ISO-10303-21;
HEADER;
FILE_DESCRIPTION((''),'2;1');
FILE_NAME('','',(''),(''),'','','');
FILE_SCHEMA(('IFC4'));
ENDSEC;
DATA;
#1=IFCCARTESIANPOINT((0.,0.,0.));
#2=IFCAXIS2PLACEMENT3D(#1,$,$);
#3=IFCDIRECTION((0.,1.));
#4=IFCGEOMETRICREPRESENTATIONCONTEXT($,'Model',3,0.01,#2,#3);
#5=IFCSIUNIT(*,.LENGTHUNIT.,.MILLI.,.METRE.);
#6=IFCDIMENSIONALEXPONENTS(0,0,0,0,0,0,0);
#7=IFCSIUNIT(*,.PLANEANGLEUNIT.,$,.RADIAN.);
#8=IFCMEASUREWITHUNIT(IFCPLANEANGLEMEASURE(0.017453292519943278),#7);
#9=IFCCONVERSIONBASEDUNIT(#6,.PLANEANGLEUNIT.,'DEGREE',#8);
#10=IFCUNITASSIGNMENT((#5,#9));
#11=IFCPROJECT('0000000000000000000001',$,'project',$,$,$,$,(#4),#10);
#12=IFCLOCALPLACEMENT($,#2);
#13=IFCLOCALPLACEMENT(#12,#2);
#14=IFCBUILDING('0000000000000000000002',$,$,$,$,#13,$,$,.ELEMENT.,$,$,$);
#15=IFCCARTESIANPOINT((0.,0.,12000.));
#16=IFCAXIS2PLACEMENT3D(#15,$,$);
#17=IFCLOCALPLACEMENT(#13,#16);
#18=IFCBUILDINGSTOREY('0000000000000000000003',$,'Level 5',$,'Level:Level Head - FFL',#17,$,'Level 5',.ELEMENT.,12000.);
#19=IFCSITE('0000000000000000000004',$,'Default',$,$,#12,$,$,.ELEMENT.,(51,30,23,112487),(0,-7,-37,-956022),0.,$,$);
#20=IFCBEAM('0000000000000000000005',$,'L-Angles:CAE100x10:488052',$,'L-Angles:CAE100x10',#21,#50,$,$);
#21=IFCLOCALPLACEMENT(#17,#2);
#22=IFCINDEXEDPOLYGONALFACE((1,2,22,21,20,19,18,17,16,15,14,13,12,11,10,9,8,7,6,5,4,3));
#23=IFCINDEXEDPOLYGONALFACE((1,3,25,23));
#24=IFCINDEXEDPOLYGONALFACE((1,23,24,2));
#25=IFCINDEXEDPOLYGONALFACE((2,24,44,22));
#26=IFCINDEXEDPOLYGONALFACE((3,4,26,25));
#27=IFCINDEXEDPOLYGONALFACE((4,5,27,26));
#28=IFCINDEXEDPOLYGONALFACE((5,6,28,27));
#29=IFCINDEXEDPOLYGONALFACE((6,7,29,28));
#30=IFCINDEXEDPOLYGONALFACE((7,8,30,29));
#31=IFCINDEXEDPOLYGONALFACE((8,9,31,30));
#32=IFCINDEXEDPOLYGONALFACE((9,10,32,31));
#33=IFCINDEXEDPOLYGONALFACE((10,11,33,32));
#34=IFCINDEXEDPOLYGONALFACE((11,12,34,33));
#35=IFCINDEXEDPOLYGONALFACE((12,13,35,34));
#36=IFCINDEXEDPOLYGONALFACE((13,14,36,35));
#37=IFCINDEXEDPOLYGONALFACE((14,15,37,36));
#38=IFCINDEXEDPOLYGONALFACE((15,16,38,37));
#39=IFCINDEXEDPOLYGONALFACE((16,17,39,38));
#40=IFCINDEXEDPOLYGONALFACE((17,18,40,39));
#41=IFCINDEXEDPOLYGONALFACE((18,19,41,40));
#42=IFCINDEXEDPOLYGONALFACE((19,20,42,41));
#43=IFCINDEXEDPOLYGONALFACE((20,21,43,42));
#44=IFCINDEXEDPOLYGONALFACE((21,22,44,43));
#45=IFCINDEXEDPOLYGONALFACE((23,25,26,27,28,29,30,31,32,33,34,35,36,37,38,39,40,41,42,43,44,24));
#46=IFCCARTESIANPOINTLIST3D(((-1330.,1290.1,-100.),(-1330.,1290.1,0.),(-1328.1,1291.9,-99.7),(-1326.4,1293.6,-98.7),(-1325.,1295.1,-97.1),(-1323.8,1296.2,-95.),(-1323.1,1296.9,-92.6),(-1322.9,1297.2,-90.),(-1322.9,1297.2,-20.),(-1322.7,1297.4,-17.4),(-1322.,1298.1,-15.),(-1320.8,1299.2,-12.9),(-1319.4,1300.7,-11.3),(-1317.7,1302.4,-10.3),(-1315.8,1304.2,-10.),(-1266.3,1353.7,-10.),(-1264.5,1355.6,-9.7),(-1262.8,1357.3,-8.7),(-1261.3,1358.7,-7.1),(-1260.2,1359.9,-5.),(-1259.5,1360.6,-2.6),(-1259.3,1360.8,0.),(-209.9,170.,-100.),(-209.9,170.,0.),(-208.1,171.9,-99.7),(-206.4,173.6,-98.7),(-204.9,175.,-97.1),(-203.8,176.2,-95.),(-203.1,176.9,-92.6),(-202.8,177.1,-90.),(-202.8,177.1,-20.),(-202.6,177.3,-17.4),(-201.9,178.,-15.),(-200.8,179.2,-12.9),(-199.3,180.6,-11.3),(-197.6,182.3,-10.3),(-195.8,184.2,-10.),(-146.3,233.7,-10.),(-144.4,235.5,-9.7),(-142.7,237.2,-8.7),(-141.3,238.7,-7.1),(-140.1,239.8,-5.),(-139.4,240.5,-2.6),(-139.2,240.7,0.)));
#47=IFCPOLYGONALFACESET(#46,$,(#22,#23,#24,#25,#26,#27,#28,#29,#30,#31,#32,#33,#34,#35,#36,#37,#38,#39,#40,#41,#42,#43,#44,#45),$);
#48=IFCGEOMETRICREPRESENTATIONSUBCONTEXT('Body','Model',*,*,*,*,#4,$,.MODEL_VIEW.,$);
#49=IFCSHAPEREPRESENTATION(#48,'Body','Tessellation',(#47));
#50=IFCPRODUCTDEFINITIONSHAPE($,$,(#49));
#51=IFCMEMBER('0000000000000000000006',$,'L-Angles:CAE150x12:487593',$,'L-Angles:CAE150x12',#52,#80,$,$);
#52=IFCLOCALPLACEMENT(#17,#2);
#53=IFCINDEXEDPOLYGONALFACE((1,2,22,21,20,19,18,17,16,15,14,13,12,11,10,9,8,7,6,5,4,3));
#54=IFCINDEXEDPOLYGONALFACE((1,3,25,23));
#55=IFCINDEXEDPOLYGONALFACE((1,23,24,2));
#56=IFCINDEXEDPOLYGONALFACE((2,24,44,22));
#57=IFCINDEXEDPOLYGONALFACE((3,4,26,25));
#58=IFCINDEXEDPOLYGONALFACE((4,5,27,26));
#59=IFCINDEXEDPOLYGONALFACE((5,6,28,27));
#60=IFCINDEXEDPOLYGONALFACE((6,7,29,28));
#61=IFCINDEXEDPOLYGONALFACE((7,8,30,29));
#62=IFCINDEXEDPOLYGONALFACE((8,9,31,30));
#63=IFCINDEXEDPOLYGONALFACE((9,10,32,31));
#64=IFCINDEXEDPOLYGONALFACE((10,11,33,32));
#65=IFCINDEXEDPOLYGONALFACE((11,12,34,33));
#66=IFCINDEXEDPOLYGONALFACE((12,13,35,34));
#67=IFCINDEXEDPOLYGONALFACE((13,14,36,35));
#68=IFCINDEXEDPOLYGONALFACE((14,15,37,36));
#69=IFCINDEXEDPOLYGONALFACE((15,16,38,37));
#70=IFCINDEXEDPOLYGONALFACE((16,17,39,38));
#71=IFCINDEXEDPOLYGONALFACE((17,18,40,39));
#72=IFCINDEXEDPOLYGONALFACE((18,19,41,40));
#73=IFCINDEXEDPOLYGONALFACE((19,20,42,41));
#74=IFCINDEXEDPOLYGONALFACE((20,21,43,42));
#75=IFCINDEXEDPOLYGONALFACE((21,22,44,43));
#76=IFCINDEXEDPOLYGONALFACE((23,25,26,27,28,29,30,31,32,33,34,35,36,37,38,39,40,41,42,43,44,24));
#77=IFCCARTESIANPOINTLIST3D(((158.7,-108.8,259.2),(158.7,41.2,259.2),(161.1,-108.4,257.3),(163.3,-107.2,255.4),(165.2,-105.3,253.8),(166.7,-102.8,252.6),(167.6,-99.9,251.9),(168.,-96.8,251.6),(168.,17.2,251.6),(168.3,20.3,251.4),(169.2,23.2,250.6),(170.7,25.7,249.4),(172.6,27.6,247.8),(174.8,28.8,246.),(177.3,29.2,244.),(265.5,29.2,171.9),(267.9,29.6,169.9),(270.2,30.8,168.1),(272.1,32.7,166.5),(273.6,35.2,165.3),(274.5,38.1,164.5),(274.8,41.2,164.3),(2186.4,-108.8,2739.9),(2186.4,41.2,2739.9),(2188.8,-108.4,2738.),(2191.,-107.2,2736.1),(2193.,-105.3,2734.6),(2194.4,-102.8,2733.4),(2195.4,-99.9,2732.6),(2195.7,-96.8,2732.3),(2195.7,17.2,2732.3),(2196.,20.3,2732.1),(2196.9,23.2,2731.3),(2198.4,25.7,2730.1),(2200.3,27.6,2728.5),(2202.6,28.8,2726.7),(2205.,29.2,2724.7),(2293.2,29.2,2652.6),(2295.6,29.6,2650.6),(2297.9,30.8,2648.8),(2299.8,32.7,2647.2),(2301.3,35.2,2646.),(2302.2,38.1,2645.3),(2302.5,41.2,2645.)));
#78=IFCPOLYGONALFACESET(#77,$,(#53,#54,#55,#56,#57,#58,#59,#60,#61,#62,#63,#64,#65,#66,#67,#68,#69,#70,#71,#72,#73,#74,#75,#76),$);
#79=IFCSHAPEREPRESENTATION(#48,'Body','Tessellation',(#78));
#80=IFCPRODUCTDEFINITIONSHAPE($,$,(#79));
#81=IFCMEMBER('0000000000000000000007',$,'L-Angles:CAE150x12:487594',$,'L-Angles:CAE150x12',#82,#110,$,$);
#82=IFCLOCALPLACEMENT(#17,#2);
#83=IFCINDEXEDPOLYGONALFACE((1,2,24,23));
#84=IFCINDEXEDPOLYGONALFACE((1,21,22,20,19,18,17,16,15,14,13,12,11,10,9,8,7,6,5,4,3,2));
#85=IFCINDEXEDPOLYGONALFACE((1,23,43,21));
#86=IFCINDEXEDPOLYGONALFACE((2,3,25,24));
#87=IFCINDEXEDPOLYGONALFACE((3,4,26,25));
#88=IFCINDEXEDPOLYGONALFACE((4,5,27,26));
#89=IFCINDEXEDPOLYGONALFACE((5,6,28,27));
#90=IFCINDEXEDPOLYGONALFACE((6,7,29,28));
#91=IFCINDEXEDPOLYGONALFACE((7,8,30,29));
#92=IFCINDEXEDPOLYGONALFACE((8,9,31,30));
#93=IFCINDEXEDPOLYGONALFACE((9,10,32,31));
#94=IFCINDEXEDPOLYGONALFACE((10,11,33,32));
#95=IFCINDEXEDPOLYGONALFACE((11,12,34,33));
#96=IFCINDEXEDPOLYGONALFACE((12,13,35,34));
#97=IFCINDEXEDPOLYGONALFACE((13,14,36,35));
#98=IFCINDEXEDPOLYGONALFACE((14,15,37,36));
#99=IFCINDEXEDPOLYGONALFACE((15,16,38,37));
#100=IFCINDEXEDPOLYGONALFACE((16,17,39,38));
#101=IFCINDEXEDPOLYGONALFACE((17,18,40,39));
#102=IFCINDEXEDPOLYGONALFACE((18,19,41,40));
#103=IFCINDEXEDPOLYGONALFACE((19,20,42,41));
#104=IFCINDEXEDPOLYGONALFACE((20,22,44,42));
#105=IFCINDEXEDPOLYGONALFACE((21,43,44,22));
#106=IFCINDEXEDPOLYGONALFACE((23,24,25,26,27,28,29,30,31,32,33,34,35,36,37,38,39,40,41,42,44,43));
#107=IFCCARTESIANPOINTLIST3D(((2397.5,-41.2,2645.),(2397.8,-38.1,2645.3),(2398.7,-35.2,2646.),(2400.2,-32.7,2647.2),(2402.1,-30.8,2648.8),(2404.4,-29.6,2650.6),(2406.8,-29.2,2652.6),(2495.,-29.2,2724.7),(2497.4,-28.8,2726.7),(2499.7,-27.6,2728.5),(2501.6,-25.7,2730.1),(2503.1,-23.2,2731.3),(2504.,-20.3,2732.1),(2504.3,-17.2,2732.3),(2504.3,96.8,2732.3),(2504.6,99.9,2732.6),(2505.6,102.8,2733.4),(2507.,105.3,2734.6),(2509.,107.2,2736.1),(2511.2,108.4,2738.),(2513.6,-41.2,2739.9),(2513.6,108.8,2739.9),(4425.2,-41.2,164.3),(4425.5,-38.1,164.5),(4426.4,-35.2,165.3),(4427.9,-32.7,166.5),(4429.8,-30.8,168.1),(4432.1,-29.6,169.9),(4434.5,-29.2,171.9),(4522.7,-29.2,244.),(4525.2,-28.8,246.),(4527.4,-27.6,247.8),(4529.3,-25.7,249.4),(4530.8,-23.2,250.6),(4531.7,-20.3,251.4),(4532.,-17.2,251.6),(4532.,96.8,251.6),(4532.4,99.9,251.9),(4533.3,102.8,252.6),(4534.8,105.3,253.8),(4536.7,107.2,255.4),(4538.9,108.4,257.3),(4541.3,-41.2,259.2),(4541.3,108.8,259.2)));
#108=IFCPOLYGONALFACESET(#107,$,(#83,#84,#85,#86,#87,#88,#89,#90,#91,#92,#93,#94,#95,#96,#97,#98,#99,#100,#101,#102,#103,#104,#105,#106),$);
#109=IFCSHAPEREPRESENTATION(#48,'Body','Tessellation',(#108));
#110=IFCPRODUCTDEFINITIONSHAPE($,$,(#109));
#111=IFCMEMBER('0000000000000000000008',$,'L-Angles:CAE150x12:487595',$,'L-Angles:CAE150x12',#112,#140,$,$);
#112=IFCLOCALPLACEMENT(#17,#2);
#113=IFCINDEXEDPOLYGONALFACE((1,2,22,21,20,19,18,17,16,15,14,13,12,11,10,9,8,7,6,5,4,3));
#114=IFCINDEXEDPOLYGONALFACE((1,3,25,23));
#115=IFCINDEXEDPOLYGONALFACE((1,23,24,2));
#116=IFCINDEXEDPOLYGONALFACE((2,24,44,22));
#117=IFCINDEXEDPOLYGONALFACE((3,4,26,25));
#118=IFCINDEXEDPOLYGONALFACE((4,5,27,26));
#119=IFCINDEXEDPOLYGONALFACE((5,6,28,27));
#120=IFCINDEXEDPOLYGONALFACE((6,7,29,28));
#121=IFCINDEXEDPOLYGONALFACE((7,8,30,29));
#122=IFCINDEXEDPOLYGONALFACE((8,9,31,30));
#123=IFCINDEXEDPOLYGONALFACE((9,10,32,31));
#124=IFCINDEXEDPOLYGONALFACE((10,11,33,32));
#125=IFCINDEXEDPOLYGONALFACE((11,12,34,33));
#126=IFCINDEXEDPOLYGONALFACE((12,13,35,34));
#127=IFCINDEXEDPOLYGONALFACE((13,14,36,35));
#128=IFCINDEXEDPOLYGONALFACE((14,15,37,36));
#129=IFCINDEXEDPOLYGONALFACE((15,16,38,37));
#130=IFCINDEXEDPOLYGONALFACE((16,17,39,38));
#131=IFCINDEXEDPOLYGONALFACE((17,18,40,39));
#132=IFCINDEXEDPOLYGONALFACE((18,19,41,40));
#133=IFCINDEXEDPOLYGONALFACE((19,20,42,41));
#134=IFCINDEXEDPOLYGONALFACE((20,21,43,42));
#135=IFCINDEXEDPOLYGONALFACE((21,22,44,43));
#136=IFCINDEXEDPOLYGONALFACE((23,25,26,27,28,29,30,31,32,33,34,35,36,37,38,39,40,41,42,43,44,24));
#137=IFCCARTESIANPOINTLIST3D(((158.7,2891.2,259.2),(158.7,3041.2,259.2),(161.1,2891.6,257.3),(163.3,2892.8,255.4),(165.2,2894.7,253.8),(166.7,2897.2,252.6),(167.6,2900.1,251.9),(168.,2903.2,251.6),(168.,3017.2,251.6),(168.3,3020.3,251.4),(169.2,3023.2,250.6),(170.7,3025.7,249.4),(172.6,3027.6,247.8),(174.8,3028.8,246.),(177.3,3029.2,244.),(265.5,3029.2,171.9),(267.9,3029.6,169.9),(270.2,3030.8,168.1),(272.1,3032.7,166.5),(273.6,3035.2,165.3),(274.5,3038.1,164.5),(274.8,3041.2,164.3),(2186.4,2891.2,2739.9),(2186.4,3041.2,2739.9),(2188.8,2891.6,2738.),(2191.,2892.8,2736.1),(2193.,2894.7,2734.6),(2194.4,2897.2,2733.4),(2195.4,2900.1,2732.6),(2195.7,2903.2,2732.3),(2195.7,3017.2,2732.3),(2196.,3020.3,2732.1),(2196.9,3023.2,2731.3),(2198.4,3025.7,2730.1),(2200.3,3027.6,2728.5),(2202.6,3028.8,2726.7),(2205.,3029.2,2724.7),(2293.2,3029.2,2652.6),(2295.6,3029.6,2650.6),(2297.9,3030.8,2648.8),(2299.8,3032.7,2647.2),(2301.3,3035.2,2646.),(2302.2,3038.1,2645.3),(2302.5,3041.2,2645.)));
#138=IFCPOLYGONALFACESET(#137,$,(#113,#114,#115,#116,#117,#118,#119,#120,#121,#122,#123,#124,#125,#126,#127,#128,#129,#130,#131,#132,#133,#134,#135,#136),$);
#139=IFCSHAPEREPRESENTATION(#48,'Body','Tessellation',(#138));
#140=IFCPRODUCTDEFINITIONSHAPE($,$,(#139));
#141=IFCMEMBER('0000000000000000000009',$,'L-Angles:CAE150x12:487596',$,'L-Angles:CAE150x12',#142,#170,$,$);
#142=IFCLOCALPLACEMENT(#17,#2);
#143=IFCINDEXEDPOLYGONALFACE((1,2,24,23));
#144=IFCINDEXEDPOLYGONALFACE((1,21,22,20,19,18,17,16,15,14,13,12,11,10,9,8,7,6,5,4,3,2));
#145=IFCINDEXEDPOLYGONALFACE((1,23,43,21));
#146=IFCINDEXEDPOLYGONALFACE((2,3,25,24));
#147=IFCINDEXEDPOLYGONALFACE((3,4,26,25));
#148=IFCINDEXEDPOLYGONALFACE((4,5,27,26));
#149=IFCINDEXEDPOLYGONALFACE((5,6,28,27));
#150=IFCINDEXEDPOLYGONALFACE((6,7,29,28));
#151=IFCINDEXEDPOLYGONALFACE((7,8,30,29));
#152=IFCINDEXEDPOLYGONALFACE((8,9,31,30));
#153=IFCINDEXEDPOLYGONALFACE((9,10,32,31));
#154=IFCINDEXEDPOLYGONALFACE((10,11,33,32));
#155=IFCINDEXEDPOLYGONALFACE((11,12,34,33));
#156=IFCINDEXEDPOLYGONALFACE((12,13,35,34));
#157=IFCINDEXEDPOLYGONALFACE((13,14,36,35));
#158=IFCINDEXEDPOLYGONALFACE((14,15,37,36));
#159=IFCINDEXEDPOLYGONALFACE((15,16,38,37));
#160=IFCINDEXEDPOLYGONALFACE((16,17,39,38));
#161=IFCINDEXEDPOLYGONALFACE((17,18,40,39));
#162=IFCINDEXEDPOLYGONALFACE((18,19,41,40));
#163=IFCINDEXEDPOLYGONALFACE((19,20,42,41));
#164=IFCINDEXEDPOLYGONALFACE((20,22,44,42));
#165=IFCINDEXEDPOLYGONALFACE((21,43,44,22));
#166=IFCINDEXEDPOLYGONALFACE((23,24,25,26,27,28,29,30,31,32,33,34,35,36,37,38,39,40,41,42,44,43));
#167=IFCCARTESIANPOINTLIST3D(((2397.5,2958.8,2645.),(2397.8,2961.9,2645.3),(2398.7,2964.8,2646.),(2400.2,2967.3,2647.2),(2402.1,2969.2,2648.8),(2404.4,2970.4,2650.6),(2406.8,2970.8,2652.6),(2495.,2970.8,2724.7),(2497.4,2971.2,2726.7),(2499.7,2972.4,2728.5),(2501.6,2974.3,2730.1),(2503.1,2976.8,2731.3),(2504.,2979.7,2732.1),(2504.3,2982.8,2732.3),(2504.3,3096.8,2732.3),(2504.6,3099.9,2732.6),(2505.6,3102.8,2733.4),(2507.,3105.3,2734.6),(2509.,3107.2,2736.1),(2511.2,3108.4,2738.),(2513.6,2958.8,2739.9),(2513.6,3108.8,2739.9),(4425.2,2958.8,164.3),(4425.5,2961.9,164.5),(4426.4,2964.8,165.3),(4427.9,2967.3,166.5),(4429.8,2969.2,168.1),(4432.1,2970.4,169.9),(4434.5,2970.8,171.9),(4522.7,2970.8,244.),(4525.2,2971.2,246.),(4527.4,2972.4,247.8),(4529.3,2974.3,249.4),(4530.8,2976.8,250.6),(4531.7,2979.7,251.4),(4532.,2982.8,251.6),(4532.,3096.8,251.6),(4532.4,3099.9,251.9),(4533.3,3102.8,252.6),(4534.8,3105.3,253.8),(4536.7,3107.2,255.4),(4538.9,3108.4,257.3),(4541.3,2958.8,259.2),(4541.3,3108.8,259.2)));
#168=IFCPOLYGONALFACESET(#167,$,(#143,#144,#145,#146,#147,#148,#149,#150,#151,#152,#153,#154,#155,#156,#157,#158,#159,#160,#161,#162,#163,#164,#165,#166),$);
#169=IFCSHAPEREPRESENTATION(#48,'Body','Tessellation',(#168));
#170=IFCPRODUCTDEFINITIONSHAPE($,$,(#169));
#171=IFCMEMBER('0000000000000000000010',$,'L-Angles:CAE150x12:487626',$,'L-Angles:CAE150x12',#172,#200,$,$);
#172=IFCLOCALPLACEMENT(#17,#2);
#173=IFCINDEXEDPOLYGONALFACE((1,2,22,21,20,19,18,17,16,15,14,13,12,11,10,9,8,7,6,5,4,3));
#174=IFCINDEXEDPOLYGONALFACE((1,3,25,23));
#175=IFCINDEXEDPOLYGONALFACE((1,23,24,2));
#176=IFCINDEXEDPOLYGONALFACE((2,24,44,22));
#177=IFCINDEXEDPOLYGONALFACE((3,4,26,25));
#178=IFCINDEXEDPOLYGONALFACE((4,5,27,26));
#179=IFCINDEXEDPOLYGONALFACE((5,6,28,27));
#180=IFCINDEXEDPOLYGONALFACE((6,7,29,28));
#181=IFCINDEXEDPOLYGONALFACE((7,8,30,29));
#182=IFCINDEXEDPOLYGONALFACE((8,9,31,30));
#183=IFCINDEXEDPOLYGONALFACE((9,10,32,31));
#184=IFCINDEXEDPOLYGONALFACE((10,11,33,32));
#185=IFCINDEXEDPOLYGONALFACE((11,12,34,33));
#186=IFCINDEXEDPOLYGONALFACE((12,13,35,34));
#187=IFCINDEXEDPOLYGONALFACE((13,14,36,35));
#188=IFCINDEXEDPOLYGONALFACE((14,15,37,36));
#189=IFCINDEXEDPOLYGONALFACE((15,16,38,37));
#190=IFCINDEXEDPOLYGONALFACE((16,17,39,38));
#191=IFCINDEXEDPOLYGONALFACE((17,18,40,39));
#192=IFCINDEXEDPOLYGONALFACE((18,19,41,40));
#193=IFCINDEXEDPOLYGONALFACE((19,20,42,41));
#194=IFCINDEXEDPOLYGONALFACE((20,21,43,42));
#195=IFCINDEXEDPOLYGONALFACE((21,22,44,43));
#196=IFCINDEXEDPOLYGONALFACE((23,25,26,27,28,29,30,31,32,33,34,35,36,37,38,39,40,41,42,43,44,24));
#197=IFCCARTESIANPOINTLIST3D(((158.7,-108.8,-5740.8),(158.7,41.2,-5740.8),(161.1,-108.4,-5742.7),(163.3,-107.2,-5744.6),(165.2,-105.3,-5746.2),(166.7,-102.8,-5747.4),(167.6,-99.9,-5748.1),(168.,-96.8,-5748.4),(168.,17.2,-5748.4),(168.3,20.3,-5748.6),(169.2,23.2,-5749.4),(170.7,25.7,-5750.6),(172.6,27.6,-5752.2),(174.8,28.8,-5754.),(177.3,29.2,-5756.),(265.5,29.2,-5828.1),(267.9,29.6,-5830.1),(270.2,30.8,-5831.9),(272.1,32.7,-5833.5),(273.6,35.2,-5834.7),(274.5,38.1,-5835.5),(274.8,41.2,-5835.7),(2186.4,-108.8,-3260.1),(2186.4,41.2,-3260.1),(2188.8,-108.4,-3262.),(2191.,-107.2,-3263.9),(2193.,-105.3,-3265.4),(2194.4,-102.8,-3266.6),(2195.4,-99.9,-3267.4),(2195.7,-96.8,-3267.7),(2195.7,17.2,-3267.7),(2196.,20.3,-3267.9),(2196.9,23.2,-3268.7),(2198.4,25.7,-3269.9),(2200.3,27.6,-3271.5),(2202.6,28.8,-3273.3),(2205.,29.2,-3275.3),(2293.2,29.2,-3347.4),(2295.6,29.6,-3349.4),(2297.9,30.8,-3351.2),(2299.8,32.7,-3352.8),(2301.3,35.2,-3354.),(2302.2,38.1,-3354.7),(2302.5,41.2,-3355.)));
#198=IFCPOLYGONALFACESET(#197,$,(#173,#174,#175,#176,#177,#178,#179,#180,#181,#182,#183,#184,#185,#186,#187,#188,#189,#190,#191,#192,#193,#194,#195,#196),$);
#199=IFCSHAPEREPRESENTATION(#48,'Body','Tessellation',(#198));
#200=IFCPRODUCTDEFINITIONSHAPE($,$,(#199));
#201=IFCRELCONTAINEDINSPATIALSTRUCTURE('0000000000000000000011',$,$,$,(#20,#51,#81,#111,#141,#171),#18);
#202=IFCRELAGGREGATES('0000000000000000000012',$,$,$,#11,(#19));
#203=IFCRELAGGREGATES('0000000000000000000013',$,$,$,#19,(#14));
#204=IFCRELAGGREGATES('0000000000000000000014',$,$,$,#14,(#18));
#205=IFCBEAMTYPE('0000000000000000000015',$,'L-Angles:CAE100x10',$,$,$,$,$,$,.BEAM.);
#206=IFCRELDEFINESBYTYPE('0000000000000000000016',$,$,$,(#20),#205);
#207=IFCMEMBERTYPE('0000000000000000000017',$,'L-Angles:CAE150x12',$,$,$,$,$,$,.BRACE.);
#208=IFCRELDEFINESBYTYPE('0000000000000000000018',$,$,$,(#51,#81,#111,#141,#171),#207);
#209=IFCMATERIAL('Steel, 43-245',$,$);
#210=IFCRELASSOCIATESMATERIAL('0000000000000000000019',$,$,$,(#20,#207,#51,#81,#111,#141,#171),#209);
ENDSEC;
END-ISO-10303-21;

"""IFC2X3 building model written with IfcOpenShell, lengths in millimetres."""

from ifc_helpers import new_model, entity, si_unit, converted_unit, direction, frame, frame_2d, origin, place, context, subcontext, project, spatial, polyline, circle_curve, parameter, trimmed, segment, composite_curve, outline, extrude, source, transform, mapped, material, type_object, type_shapes, element, save


model = new_model("IFC2X3")

# Units and contexts
model_context = context("Model", 3, precision=0.01, world=origin(), true_north=direction((0.0, 1.0)))
body_context = subcontext(model_context, "Body", "Model", "MODEL_VIEW")
ifc_project = project(units=[si_unit("LENGTHUNIT", "METRE", prefix="MILLI"), converted_unit("PLANEANGLEUNIT", "DEGREE", entity("IfcPlaneAngleMeasure", 0.017453292519943278), si_unit("PLANEANGLEUNIT", "RADIAN"), dimensions=[0, 0, 0, 0, 0, 0, 0])], contexts=[model_context])

# Site, building, storey
site_placement = place(None, origin())
site = spatial("IfcSite", under=ifc_project, at=site_placement, Name="Default", CompositionType="ELEMENT", RefLatitude=(51, 30, 23, 112487), RefLongitude=(0, -7, -37, -956022), RefElevation=0.0)
building_placement = place(site_placement, origin())
building = spatial("IfcBuilding", under=site, at=building_placement, CompositionType="ELEMENT")
storey_placement = place(building_placement, frame((0.0, 0.0, 12000.0)))
storey = spatial("IfcBuildingStorey", under=building, at=storey_placement, Name="Level 5", ObjectType="Level:Level Head - FFL", LongName="Level 5", CompositionType="ELEMENT", Elevation=12000.0)

# Beam
ifc_material = material(Name="Steel, 43-245")
beam_type_1 = type_object("IfcBeamType", Name="L-Angles:CAE100x10", PredefinedType="BEAM")
beam_1_placement = place(storey_placement, frame((0.0, 0.0, 0.0), z_axis=(0.0, 0.0, 1.0), x_axis=(-0.707107, 0.707107, 0.0)))
element("IfcBeam", 1, at=beam_1_placement, inside=storey, type_object=beam_type_1, material=ifc_material, Name="L-Angles:CAE100x10:488052", ObjectType="L-Angles:CAE100x10", context=body_context, shape_type="SweptSolid", body=[
    extrude(outline(composite_curve([segment(polyline([(-67.1, -32.9), (32.9, -32.9)]), True, "CONTINUOUS"), segment(polyline([(32.9, -32.9), (32.9, 67.1)]), True, "CONTINUOUS"), segment(trimmed(circle_curve(frame_2d((32.9, 57.1), x_axis=(0.0, 1.0)), 10.0), [parameter(0.0)], [parameter(90.0)], True, "PARAMETER"), True, "CONTINUOUS"), segment(polyline([(22.9, 57.1), (22.9, -12.9)]), True, "CONTINUOUS"), segment(trimmed(circle_curve(frame_2d((12.9, -12.9), x_axis=(1.0, 0.0)), 10.0), [parameter(270.0)], [parameter(0.0)], True, "PARAMETER"), False, "CONTINUOUS"), segment(polyline([(12.9, -22.9), (-57.1, -22.9)]), True, "CONTINUOUS"), segment(trimmed(circle_curve(frame_2d((-57.1, -32.9), x_axis=(0.0, 1.0)), 10.0), [parameter(0.0)], [parameter(90.0)], True, "PARAMETER"), True, "CONTINUOUS")], self_intersect=False)), frame((268.7, -4.7, -32.9), z_axis=(1.0, 0.0, 0.0), x_axis=(0.0, 0.0, 1.0)), (0.0, 0.0, 1.0), 1584.0),
])

# Members
member_type_1 = type_object("IfcMemberType", Name="L-Angles:CAE150x12", PredefinedType="BRACE", material=ifc_material)
shared_shape_1 = source(origin(), body_context, "Body", "SweptSolid", [
    extrude(outline(composite_curve([segment(polyline([(-102.0, -48.0), (48.0, -48.0)]), True, "CONTINUOUS"), segment(polyline([(48.0, -48.0), (48.0, 102.0)]), True, "CONTINUOUS"), segment(trimmed(circle_curve(frame_2d((48.0, 90.0), x_axis=(0.0, 1.0)), 12.0), [parameter(0.0)], [parameter(90.0)], True, "PARAMETER"), True, "CONTINUOUS"), segment(polyline([(36.0, 90.0), (36.0, -24.0)]), True, "CONTINUOUS"), segment(trimmed(circle_curve(frame_2d((24.0, -24.0), x_axis=(1.0, 0.0)), 12.0), [parameter(270.0)], [parameter(0.0)], True, "PARAMETER"), False, "CONTINUOUS"), segment(polyline([(24.0, -36.0), (-90.0, -36.0)]), True, "CONTINUOUS"), segment(trimmed(circle_curve(frame_2d((-90.0, -48.0), x_axis=(0.0, 1.0)), 12.0), [parameter(0.0)], [parameter(90.0)], True, "PARAMETER"), True, "CONTINUOUS")], self_intersect=False)), frame((-1555.5, -6.8, -6.8), z_axis=(1.0, 0.0, 0.0), x_axis=(0.0, 0.0, 1.0)), (0.0, 0.0, 1.0), 3204.0),
])
type_shapes(member_type_1, [shared_shape_1])
for number, where, z_axis, x_axis, name in (
    (2, (1175.0, 0.0, 1437.5), (-0.774257, 0.0, 0.632871), (0.632871, 0.0, 0.774257), "L-Angles:CAE150x12:487593"),
    (3, (3525.0, 0.0, 1437.5), (0.774257, 0.0, 0.632871), (-0.632871, 0.0, 0.774257), "L-Angles:CAE150x12:487594"),
    (4, (1175.0, 3000.0, 1437.5), (-0.774257, 0.0, 0.632871), (0.632871, 0.0, 0.774257), "L-Angles:CAE150x12:487595"),
    (5, (3525.0, 3000.0, 1437.5), (0.774257, 0.0, 0.632871), (-0.632871, 0.0, 0.774257), "L-Angles:CAE150x12:487596"),
    (6, (1175.0, 0.0, -4562.5), (-0.774257, 0.0, 0.632871), (0.632871, 0.0, 0.774257), "L-Angles:CAE150x12:487626"),
):
    element("IfcMember", number, at=place(storey_placement, frame(where, z_axis=z_axis, x_axis=x_axis)), inside=storey, type_object=member_type_1, material=ifc_material, Name=name, ObjectType="L-Angles:CAE150x12", context=body_context, shape_type="MappedRepresentation", body=[
        mapped(shared_shape_1, transform((0.0, 0.0, 0.0), scale=1.0)),
    ])

save(model, "model.ifc")
